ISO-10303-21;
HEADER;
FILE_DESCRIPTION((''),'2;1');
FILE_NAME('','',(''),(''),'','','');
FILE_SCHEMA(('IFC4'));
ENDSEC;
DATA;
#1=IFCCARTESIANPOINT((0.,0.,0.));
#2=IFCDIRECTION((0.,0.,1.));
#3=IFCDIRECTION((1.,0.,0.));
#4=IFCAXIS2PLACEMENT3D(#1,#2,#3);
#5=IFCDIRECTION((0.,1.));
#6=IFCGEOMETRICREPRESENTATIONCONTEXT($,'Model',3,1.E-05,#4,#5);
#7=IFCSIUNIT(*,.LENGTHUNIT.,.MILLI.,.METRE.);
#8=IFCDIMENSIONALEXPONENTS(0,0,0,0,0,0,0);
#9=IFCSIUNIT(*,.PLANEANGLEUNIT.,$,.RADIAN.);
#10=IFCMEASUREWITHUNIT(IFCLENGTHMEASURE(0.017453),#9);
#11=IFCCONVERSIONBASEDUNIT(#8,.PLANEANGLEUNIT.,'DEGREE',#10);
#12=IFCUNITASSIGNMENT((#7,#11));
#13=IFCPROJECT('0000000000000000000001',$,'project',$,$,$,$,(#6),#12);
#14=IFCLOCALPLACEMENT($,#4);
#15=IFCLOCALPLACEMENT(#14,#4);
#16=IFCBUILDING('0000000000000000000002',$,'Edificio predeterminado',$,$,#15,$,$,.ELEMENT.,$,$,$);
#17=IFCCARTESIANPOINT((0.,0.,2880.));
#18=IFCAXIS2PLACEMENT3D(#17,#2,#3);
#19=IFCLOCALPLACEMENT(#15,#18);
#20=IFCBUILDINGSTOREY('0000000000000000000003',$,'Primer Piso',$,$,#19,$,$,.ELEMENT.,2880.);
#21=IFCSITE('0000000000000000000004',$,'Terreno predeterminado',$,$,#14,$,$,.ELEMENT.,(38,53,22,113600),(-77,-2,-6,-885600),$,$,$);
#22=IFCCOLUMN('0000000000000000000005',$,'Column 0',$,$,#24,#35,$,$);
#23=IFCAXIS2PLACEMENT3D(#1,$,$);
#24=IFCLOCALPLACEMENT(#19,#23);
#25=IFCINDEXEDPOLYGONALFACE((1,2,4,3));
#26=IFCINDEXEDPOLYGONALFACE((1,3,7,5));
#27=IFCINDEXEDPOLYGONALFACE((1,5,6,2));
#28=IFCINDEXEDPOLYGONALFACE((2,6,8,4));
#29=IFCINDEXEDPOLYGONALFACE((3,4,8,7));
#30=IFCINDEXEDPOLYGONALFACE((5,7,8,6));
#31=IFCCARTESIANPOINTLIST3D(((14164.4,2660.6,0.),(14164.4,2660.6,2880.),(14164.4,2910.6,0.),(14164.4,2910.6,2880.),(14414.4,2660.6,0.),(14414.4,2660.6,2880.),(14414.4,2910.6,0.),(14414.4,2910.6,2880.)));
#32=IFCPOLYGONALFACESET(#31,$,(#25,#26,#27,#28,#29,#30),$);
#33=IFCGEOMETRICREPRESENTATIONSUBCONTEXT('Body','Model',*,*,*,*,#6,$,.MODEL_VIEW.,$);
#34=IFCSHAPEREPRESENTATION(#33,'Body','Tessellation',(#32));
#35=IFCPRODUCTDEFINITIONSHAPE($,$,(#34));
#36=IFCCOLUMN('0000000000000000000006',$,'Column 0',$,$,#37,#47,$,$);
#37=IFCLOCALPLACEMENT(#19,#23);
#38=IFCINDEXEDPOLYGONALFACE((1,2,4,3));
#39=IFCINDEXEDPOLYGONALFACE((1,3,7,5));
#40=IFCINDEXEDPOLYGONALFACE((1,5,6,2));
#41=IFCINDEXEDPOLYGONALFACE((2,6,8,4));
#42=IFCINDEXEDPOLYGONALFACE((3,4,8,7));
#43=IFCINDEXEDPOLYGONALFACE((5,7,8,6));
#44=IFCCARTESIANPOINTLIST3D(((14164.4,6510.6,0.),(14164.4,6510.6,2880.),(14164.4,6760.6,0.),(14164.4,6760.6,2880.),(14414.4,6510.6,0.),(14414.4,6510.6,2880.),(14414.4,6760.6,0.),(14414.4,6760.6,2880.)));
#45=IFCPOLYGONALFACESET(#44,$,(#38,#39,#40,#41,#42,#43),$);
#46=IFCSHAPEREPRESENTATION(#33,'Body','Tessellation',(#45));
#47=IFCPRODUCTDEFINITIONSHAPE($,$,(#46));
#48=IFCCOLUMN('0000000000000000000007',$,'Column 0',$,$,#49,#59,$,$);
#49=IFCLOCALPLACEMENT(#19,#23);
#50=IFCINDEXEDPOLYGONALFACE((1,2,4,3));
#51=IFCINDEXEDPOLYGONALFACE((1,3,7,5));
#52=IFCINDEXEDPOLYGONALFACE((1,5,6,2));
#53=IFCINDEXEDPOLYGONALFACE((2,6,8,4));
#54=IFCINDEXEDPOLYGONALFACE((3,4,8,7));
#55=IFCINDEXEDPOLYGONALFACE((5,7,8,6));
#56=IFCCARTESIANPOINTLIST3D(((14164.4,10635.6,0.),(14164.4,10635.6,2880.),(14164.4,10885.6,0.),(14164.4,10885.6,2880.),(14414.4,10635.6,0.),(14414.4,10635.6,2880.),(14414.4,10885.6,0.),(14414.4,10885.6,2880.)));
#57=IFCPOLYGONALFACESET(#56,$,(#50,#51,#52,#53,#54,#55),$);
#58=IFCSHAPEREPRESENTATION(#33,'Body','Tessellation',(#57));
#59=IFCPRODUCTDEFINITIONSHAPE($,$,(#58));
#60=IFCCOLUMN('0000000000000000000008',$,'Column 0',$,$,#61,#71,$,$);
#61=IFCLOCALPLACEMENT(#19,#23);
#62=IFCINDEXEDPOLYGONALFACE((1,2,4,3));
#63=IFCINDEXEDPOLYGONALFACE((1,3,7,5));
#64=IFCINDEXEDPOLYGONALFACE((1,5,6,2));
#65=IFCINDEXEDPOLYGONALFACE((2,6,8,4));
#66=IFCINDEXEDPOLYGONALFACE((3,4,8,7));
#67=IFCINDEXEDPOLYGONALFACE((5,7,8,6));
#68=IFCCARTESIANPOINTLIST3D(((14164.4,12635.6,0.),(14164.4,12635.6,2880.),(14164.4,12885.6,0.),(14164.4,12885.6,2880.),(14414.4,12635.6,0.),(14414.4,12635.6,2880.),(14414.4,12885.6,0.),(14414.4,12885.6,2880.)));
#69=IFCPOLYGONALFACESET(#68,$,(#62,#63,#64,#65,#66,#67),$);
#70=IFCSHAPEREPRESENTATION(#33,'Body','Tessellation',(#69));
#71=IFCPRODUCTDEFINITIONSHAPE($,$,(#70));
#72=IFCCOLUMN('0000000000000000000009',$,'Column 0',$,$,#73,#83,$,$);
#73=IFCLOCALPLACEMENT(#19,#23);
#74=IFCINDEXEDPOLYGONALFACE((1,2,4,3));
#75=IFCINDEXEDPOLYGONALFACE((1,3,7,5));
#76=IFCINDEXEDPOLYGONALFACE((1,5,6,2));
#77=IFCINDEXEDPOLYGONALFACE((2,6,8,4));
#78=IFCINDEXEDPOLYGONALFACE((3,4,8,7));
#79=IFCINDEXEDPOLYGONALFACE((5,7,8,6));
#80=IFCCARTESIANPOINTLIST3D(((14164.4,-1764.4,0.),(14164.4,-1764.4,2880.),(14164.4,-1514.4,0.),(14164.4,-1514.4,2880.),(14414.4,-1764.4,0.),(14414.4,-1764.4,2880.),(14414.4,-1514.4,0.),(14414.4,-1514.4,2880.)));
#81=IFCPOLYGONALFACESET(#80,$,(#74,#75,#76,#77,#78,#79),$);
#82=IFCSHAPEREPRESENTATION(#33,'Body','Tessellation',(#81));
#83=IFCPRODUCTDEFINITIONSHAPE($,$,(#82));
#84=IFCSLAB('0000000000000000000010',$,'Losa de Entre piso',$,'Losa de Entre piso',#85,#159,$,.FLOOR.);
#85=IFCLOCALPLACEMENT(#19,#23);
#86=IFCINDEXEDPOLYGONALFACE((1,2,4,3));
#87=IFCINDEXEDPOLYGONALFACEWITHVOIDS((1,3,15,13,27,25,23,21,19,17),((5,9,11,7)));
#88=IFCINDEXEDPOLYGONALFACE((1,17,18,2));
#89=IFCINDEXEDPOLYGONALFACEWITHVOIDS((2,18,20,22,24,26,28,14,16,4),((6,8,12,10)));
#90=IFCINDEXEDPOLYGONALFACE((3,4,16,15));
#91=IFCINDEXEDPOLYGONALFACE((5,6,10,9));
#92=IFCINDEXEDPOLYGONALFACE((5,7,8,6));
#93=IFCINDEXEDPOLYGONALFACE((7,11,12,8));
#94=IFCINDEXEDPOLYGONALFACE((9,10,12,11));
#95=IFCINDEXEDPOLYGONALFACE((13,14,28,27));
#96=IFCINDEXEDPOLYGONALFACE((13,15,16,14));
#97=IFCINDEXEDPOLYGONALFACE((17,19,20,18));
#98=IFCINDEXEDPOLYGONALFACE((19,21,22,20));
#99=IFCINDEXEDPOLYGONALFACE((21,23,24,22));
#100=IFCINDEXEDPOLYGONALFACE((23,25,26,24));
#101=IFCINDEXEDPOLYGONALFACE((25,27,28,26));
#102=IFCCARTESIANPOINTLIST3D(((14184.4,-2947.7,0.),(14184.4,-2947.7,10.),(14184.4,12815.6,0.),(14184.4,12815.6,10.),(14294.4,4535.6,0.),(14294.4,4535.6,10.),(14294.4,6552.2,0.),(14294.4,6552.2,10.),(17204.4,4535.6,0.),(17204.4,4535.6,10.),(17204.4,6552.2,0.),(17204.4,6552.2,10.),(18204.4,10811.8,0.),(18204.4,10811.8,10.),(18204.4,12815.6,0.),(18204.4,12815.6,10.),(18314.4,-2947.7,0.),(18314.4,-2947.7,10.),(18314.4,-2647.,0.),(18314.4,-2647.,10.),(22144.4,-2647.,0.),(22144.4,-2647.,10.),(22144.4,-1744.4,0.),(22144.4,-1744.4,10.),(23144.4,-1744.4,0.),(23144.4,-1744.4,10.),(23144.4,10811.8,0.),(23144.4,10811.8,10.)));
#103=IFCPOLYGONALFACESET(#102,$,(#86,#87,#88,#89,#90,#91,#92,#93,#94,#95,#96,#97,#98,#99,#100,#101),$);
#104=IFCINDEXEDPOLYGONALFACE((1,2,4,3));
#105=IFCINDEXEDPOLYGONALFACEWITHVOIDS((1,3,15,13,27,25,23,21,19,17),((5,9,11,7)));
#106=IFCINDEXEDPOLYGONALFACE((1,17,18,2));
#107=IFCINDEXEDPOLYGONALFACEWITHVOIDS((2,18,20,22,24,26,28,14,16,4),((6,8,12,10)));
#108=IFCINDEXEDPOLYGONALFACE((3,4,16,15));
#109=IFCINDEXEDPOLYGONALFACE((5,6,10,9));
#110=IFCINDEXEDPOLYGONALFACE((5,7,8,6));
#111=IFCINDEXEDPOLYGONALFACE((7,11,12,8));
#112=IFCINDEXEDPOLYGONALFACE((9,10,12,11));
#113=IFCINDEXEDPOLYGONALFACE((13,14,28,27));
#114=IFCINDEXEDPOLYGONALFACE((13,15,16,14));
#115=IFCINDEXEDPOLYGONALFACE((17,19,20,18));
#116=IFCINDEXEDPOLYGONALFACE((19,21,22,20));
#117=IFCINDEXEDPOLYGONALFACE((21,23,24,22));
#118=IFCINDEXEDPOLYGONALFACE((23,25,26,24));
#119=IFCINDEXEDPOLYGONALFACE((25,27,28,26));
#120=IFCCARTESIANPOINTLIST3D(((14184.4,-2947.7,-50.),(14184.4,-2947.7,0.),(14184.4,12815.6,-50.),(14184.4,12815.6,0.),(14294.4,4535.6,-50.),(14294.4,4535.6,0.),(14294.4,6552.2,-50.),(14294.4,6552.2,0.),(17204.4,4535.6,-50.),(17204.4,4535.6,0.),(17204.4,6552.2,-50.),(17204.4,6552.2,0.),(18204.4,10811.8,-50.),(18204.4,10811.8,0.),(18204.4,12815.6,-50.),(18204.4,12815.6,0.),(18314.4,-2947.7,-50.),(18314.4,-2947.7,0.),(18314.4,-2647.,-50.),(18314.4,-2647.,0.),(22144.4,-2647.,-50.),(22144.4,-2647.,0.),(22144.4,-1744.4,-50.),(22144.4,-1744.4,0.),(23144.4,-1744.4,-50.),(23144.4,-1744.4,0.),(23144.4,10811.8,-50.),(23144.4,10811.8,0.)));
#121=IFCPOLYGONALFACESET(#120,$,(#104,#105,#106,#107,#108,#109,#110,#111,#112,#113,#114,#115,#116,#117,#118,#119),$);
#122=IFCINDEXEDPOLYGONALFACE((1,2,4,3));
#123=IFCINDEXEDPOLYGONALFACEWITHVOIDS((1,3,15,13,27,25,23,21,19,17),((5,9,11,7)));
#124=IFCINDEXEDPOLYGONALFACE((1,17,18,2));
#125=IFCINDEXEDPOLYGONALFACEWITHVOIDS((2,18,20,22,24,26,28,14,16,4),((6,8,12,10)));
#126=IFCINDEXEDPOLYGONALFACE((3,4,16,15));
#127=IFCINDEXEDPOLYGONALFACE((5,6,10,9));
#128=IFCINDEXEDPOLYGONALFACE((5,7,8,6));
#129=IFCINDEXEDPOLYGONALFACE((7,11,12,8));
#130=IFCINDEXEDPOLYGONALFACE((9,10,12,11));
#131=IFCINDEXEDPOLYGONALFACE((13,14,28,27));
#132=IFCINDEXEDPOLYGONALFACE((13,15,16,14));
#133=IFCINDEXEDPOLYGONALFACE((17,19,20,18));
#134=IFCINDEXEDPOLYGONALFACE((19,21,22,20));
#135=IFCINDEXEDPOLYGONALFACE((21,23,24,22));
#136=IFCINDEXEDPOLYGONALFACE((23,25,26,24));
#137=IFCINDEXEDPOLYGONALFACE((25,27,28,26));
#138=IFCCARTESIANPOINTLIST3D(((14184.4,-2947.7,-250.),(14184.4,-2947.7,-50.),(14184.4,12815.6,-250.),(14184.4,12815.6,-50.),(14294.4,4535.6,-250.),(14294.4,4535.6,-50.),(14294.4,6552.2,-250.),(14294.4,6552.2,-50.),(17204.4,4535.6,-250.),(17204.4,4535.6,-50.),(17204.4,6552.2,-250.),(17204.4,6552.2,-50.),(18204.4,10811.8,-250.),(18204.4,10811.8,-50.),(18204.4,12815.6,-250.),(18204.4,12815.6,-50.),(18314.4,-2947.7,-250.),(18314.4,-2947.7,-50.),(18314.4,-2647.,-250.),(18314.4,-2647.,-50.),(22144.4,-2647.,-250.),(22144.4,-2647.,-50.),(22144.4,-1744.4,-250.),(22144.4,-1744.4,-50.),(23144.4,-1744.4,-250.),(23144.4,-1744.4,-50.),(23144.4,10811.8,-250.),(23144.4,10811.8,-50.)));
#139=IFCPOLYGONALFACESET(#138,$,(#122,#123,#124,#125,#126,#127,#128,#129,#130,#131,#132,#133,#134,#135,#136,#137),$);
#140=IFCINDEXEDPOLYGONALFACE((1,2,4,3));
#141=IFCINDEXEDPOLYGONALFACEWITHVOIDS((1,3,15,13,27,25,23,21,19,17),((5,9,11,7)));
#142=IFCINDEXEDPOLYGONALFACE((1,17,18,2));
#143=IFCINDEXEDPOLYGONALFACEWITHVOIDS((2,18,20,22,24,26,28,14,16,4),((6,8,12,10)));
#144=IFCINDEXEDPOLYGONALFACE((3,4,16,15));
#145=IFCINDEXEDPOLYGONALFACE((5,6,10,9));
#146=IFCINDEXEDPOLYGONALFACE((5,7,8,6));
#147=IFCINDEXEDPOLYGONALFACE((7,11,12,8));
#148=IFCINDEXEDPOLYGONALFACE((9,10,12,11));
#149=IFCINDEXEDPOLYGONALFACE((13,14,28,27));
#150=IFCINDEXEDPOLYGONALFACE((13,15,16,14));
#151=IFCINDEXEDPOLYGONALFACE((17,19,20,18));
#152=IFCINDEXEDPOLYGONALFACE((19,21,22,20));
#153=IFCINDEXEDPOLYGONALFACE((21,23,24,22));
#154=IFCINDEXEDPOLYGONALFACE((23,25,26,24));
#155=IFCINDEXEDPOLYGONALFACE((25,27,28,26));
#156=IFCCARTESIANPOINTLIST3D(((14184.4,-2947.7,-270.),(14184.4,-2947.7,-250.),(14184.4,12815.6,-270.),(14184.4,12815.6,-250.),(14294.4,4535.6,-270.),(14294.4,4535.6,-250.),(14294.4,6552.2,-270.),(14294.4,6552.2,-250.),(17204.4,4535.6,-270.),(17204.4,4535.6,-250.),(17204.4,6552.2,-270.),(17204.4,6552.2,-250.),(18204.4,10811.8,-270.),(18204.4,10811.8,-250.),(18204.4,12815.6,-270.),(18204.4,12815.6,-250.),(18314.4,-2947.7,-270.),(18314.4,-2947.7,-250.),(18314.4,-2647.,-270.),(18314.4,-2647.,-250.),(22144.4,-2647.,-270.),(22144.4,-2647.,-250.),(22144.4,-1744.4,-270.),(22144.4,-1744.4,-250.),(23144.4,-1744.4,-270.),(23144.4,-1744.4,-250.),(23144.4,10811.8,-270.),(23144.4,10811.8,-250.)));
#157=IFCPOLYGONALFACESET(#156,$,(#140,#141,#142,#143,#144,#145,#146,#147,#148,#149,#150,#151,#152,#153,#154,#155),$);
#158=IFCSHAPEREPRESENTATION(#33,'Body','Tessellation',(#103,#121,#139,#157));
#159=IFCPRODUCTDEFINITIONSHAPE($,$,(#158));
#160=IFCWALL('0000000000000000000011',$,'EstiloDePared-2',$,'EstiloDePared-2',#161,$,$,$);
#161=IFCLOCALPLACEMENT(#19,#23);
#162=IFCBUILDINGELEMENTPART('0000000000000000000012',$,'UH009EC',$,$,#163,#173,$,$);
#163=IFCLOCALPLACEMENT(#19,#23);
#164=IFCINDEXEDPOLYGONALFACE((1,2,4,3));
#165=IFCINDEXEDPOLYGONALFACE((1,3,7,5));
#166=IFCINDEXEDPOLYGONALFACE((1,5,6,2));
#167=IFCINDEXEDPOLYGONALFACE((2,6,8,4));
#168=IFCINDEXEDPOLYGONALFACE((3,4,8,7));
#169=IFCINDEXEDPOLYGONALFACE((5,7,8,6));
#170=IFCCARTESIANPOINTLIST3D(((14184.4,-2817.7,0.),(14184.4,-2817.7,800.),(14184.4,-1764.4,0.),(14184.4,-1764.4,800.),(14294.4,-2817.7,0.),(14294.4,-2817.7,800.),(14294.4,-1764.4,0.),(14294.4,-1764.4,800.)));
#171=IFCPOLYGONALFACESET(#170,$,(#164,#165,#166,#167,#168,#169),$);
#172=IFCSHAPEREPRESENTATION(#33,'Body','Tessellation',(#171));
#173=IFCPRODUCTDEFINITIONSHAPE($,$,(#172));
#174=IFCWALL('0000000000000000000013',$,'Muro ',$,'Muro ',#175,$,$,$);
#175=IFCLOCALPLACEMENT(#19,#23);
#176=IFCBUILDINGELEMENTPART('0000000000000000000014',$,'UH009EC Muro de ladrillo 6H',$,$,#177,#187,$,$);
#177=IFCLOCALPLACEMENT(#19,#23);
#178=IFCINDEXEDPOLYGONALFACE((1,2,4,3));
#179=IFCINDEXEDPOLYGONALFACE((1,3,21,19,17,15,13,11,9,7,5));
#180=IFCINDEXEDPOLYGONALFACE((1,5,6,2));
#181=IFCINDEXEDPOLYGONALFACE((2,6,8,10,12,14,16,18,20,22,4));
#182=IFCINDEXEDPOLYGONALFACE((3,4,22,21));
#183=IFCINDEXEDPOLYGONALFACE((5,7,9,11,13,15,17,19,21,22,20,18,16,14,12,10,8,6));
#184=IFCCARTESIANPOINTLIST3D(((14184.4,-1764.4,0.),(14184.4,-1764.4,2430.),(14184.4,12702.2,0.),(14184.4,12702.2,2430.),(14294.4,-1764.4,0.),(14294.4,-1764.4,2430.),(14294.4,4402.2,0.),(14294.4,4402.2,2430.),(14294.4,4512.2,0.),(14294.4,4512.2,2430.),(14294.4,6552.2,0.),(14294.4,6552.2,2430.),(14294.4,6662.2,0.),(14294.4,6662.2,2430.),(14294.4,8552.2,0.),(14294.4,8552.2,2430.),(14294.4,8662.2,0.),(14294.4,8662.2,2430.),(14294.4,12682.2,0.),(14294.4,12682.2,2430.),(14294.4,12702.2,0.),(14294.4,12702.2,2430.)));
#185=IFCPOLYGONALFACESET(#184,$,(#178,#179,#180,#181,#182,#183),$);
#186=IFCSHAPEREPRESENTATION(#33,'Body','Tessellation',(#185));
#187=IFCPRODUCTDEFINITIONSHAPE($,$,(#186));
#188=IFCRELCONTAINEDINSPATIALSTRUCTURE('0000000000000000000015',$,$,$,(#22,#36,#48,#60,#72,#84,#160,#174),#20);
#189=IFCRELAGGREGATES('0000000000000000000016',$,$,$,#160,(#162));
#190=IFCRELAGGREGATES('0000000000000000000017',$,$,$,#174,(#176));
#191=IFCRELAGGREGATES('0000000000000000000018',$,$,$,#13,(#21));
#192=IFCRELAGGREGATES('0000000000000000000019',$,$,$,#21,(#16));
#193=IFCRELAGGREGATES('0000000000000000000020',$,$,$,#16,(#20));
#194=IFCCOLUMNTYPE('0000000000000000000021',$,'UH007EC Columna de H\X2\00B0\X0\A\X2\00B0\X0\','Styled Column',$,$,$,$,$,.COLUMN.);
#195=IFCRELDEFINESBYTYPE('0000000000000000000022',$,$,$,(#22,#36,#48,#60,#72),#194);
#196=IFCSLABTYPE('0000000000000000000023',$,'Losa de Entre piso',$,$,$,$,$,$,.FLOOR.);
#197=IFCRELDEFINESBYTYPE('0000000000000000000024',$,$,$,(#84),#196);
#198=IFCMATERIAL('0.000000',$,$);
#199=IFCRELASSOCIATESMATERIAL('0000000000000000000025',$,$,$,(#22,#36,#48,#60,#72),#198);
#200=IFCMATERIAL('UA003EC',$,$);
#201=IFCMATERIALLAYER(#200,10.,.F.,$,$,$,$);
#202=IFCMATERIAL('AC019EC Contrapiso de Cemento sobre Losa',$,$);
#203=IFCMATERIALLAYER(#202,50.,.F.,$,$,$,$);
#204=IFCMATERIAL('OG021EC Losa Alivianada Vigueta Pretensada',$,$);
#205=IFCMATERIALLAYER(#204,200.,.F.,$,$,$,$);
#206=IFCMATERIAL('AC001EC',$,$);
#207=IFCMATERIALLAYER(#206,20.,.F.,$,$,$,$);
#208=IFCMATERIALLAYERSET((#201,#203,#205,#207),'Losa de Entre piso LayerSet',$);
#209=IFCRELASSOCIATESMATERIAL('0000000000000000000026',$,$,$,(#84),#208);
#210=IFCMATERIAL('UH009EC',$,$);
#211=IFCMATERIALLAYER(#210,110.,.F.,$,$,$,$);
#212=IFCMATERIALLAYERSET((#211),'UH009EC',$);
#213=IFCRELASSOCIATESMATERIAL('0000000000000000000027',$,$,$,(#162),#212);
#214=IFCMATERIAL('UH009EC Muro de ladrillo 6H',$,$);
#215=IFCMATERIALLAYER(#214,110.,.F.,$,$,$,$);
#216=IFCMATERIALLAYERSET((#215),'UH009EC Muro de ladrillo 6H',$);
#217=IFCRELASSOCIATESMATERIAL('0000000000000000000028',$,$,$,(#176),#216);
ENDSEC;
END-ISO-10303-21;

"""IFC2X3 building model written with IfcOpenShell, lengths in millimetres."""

from ifc_helpers import new_model, entity, si_unit, converted_unit, direction, frame, origin_with_axes, place, context, subcontext, project, spatial, polyline, outline, extrude, material, layer, layer_set, layer_usage, type_object, element, aggregate, save


model = new_model("IFC2X3")

# Units and contexts
model_context = context("Model", 3, precision=1e-05, world=origin_with_axes(), true_north=direction((0.0, 1.0)))
body_context = subcontext(model_context, "Body", "Model", "MODEL_VIEW")
ifc_project = project(units=[si_unit("LENGTHUNIT", "METRE", prefix="MILLI"), converted_unit("PLANEANGLEUNIT", "DEGREE", entity("IfcLengthMeasure", 0.017453), si_unit("PLANEANGLEUNIT", "RADIAN"), dimensions=[0, 0, 0, 0, 0, 0, 0])], contexts=[model_context])

# Site, building, storey
site_placement = place(None, origin_with_axes())
site = spatial("IfcSite", under=ifc_project, at=site_placement, Name="Terreno predeterminado", CompositionType="ELEMENT", RefLatitude=(38, 53, 22, 113600), RefLongitude=(-77, -2, -6, -885600))
building_placement = place(site_placement, origin_with_axes())
building = spatial("IfcBuilding", under=site, at=building_placement, Name="Edificio predeterminado", CompositionType="ELEMENT")
storey_placement = place(building_placement, frame((0.0, 0.0, 2880.0), z_axis=(0.0, 0.0, 1.0), x_axis=(1.0, 0.0, 0.0)))
storey = spatial("IfcBuildingStorey", under=building, at=storey_placement, Name="Primer Piso", CompositionType="ELEMENT", Elevation=2880.0)

# Columns
ifc_material_1 = material(Name="0.000000")
column_type = type_object("IfcColumnType", Name="UH007EC Columna de H°A°", Description="Styled Column", PredefinedType="COLUMN")
for number, where, z_axis, x_axis, name in (
    (1, (14289.4, 2785.6, 0.0), (0.0, 0.0, 1.0), (1.0, 0.0, 0.0), "Column 0"),
    (2, (14289.4, 6635.6, 0.0), (0.0, 0.0, 1.0), (1.0, 0.0, 0.0), "Column 0"),
    (3, (14289.4, 10760.6, 0.0), (0.0, 0.0, 1.0), (1.0, 0.0, 0.0), "Column 0"),
    (4, (14289.4, 12760.6, 0.0), (0.0, 0.0, 1.0), (1.0, 0.0, 0.0), "Column 0"),
    (5, (14289.4, -1639.4, 0.0), (0.0, 0.0, 1.0), (1.0, 0.0, 0.0), "Column 0"),
):
    element("IfcColumn", number, at=place(storey_placement, frame(where, z_axis=z_axis, x_axis=x_axis)), inside=storey, type_object=column_type, material=ifc_material_1, Name=name, context=body_context, shape_type="SweptSolid", body=[
        extrude(outline(polyline([(-125.0, -125.0), (125.0, -125.0), (125.0, 125.0), (-125.0, 125.0), (-125.0, -125.0)])), origin_with_axes(), (0.0, 0.0, 1.0), 2880.0),
    ])

# Slab
ifc_material_2 = material(Name="UA003EC")
ifc_layer_1 = layer(ifc_material_2, 10.0, ventilated=False)
ifc_material_3 = material(Name="AC019EC Contrapiso de Cemento sobre Losa")
ifc_layer_2 = layer(ifc_material_3, 50.0, ventilated=False)
ifc_material_4 = material(Name="OG021EC Losa Alivianada Vigueta Pretensada")
ifc_layer_3 = layer(ifc_material_4, 200.0, ventilated=False)
ifc_material_5 = material(Name="AC001EC")
ifc_layer_4 = layer(ifc_material_5, 20.0, ventilated=False)
ifc_layer_set_1 = layer_set([ifc_layer_1, ifc_layer_2, ifc_layer_3, ifc_layer_4], Name="Losa de Entre piso LayerSet")
ifc_layer_usage_1 = layer_usage(ifc_layer_set_1, "AXIS3", "NEGATIVE", 0.0)
slab_type = type_object("IfcSlabType", Name="Losa de Entre piso", PredefinedType="FLOOR")
slab_placement = place(storey_placement, frame((0.0, 0.0, -2880.0), z_axis=(0.0, 0.0, 1.0), x_axis=(1.0, 0.0, 0.0)))
element("IfcSlab", 6, at=slab_placement, inside=storey, type_object=slab_type, material=ifc_layer_usage_1, Name="Losa de Entre piso", ObjectType="Losa de Entre piso", PredefinedType="FLOOR", context=body_context, shape_type="SweptSolid", body=[
    extrude(outline(polyline([(0.0, 15763.4), (4130.0, 15763.4), (4130.0, 15462.6), (7960.0, 15462.6), (7960.0, 14560.0), (8960.0, 14560.0), (8960.0, 2003.8), (4020.0, 2003.8), (4020.0, 0.0), (0.0, 0.0), (0.0, 15763.4)]), holes=[polyline([(110.0, 6263.4), (3020.0, 6263.4), (3020.0, 8280.0), (110.0, 8280.0), (110.0, 6263.4)])]), frame((14184.4, 12815.6, 2880.0), z_axis=(0.0, 0.0, -1.0), x_axis=(1.0, 0.0, 0.0)), (0.0, 0.0, -1.0), 10.0),
    extrude(outline(polyline([(0.0, 15763.4), (4130.0, 15763.4), (4130.0, 15462.6), (7960.0, 15462.6), (7960.0, 14560.0), (8960.0, 14560.0), (8960.0, 2003.8), (4020.0, 2003.8), (4020.0, 0.0), (0.0, 0.0), (0.0, 15763.4)]), holes=[polyline([(110.0, 6263.4), (3020.0, 6263.4), (3020.0, 8280.0), (110.0, 8280.0), (110.0, 6263.4)])]), frame((14184.4, 12815.6, 2830.0), z_axis=(0.0, 0.0, -1.0), x_axis=(1.0, 0.0, 0.0)), (0.0, 0.0, -1.0), 50.0),
    extrude(outline(polyline([(0.0, 15763.4), (4130.0, 15763.4), (4130.0, 15462.6), (7960.0, 15462.6), (7960.0, 14560.0), (8960.0, 14560.0), (8960.0, 2003.8), (4020.0, 2003.8), (4020.0, 0.0), (0.0, 0.0), (0.0, 15763.4)]), holes=[polyline([(110.0, 6263.4), (3020.0, 6263.4), (3020.0, 8280.0), (110.0, 8280.0), (110.0, 6263.4)])]), frame((14184.4, 12815.6, 2630.0), z_axis=(0.0, 0.0, -1.0), x_axis=(1.0, 0.0, 0.0)), (0.0, 0.0, -1.0), 200.0),
    extrude(outline(polyline([(0.0, 15763.4), (4130.0, 15763.4), (4130.0, 15462.6), (7960.0, 15462.6), (7960.0, 14560.0), (8960.0, 14560.0), (8960.0, 2003.8), (4020.0, 2003.8), (4020.0, 0.0), (0.0, 0.0), (0.0, 15763.4)]), holes=[polyline([(110.0, 6263.4), (3020.0, 6263.4), (3020.0, 8280.0), (110.0, 8280.0), (110.0, 6263.4)])]), frame((14184.4, 12815.6, 2610.0), z_axis=(0.0, 0.0, -1.0), x_axis=(1.0, 0.0, 0.0)), (0.0, 0.0, -1.0), 20.0),
])

# Walls, building element parts
wall_1_placement = place(storey_placement, frame((14239.4, -2817.7, 0.0), z_axis=(0.0, 0.0, 1.0), x_axis=(0.0, 1.0, 0.0)))
wall_1 = element("IfcWall", 7, at=wall_1_placement, inside=storey, Name="EstiloDePared-2", ObjectType="EstiloDePared-2")
ifc_material_6 = material(Name="UH009EC")
ifc_layer_5 = layer(ifc_material_6, 110.0, ventilated=False)
ifc_layer_set_2 = layer_set([ifc_layer_5], Name="UH009EC")
ifc_layer_usage_2 = layer_usage(ifc_layer_set_2, "AXIS2", "NEGATIVE", -55.0)
building_element_part_1_placement = place(wall_1_placement, origin_with_axes())
building_element_part_1 = element("IfcBuildingElementPart", 8, at=building_element_part_1_placement, material=ifc_layer_usage_2, Name="UH009EC", context=body_context, shape_type="SweptSolid", body=[
    extrude(outline(polyline([(1053.4, 55.0), (1053.4, -55.0), (0.0, -55.0), (0.0, 55.0), (1053.4, 55.0)])), origin_with_axes(), (0.0, 0.0, 1.0), 800.0),
])
aggregate(wall_1, [building_element_part_1])
wall_2_placement = place(storey_placement, frame((14239.4, -1764.4, 0.0), z_axis=(0.0, 0.0, 1.0), x_axis=(0.0, 1.0, 0.0)))
wall_2 = element("IfcWall", 9, at=wall_2_placement, inside=storey, Name="Muro ", ObjectType="Muro ")
ifc_material_7 = material(Name="UH009EC Muro de ladrillo 6H")
ifc_layer_6 = layer(ifc_material_7, 110.0, ventilated=False)
ifc_layer_set_3 = layer_set([ifc_layer_6], Name="UH009EC Muro de ladrillo 6H")
ifc_layer_usage_3 = layer_usage(ifc_layer_set_3, "AXIS2", "NEGATIVE", -55.0)
building_element_part_2_placement = place(wall_2_placement, origin_with_axes())
building_element_part_2 = element("IfcBuildingElementPart", 10, at=building_element_part_2_placement, material=ifc_layer_usage_3, Name="UH009EC Muro de ladrillo 6H", context=body_context, shape_type="SweptSolid", body=[
    extrude(outline(polyline([(14466.6, 55.0), (14466.6, -55.0), (14446.6, -55.0), (10426.6, -55.0), (10316.6, -55.0), (8426.6, -55.0), (8316.6, -55.0), (6276.6, -55.0), (6166.6, -55.0), (0.0, -55.0), (0.0, 55.0), (14466.6, 55.0)])), origin_with_axes(), (0.0, 0.0, 1.0), 2430.0),
])
aggregate(wall_2, [building_element_part_2])

save(model, "model.ifc")
